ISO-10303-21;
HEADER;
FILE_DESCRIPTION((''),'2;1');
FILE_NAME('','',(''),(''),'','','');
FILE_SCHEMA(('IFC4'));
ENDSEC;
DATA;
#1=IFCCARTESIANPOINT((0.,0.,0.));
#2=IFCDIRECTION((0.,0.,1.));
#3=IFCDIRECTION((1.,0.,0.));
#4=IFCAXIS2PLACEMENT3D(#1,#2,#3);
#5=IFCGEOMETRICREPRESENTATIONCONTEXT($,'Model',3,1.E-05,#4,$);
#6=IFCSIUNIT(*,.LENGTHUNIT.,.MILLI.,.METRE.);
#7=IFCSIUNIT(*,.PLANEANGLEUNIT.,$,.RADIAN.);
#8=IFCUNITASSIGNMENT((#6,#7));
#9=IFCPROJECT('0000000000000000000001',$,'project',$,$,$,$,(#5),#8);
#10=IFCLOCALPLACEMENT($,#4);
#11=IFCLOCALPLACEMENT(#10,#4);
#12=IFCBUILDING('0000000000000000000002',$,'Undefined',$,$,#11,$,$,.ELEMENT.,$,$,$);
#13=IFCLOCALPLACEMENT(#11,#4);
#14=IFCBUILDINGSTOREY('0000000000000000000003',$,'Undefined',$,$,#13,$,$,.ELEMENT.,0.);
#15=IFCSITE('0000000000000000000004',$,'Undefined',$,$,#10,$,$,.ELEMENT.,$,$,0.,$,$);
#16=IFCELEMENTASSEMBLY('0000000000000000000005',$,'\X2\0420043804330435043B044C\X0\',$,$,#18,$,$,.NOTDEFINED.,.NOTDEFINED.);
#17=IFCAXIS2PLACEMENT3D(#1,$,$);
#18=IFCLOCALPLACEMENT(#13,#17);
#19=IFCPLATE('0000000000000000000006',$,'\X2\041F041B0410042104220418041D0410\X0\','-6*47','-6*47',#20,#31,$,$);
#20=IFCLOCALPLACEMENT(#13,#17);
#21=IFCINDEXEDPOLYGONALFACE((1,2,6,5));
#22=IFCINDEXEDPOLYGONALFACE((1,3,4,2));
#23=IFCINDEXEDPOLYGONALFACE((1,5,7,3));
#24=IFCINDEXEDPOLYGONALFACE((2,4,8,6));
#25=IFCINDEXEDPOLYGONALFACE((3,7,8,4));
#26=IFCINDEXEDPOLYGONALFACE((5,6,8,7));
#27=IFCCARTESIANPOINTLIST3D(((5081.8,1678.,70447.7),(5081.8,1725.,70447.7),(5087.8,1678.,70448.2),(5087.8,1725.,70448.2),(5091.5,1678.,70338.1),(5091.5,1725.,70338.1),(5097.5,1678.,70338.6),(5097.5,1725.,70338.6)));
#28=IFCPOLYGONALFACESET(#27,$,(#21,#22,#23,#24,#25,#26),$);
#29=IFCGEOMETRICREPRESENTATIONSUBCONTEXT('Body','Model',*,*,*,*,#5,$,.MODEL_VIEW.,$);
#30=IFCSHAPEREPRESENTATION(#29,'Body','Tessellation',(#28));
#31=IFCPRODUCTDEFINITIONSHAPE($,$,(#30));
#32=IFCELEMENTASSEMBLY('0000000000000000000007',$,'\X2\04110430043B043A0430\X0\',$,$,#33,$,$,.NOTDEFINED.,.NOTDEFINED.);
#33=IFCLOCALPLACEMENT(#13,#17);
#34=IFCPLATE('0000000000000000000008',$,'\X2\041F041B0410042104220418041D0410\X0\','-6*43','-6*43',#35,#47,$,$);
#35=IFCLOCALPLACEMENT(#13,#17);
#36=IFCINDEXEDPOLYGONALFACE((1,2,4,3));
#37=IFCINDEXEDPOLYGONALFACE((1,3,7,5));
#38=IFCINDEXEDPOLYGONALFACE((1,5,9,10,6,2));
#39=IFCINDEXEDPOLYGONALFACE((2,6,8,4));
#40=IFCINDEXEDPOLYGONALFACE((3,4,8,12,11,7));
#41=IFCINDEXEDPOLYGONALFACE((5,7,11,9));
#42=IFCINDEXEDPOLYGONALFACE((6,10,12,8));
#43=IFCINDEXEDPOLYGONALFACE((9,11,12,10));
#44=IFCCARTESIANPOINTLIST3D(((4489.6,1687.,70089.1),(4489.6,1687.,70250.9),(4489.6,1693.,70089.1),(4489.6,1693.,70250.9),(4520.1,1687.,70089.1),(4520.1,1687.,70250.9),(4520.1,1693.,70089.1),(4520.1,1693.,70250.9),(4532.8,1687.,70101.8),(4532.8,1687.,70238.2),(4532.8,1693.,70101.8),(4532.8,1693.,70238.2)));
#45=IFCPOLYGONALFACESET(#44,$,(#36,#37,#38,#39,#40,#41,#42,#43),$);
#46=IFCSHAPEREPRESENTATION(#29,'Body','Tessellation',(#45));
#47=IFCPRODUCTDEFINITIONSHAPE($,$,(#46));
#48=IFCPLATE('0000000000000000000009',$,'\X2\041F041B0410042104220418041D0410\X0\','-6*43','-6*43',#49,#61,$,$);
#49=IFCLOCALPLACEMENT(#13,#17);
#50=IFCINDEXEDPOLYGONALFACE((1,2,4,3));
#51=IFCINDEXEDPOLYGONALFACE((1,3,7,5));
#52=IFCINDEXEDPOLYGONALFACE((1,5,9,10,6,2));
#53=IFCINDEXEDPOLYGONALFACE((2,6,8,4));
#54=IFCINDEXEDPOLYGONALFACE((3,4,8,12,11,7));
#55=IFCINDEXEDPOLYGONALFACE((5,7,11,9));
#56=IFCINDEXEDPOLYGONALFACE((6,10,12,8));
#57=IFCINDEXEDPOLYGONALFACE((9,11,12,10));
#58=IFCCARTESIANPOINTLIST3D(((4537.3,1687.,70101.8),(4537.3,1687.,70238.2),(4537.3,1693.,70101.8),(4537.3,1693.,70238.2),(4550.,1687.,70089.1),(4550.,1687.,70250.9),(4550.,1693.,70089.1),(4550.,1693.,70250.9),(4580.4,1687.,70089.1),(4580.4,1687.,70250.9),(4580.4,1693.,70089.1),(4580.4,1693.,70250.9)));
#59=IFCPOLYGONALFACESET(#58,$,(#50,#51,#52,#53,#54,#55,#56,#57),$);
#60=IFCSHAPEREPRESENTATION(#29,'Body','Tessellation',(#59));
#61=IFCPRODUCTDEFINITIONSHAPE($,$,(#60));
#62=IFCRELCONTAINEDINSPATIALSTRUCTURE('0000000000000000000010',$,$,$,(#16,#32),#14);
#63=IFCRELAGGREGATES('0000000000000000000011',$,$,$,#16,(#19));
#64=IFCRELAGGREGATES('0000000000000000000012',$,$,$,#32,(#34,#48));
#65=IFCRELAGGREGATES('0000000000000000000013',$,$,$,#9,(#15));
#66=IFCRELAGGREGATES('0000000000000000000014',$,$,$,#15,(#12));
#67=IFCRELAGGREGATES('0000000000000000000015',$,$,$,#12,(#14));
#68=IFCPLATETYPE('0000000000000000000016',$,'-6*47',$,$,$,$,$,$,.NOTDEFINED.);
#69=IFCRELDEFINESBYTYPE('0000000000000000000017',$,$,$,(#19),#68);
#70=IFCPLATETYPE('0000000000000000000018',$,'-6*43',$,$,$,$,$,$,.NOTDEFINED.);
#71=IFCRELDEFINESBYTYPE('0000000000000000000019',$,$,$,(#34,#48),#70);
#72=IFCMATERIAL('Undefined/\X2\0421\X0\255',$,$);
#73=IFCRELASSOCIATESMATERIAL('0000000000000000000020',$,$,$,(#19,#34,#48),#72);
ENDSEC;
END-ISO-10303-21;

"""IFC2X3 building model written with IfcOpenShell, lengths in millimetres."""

from ifc_helpers import new_model, si_unit, frame, origin_with_axes, origin_2d_with_axis, place, context, subcontext, project, spatial, polyline, rectangle, outline, extrude, boolean, material, type_object, element, aggregate, save


model = new_model("IFC2X3")

# Units and contexts
model_context = context("Model", 3, precision=1e-05, world=origin_with_axes())
body_context = subcontext(model_context, "Body", "Model", "MODEL_VIEW")
ifc_project = project(units=[si_unit("LENGTHUNIT", "METRE", prefix="MILLI"), si_unit("PLANEANGLEUNIT", "RADIAN")], contexts=[model_context])

# Site, building, storey
site_placement = place(None, origin_with_axes())
site = spatial("IfcSite", under=ifc_project, at=site_placement, Name="Undefined", CompositionType="ELEMENT", RefElevation=0.0)
building_placement = place(site_placement, origin_with_axes())
building = spatial("IfcBuilding", under=site, at=building_placement, Name="Undefined", CompositionType="ELEMENT")
storey_placement = place(building_placement, origin_with_axes())
storey = spatial("IfcBuildingStorey", under=building, at=storey_placement, Name="Undefined", CompositionType="ELEMENT", Elevation=0.0)

# Shared definitions
ifc_material_1 = material(Name="Undefined/С255")

# Element assembly
assembly_1_placement = place(storey_placement, origin_with_axes())
assembly_1 = element("IfcElementAssembly", 1, at=assembly_1_placement, inside=storey, Name="Ригель", AssemblyPlace="NOTDEFINED", PredefinedType="NOTDEFINED")

# Plate
plate_type_1 = type_object("IfcPlateType", Name="-6*47", PredefinedType="NOTDEFINED")
plate_1_placement = place(assembly_1_placement, frame((5084.8, 1615.0, 70447.9), z_axis=(0.996107, 0.0, 0.088152), x_axis=(0.088152, 0.0, -0.996107)))
plate_1 = element("IfcPlate", 2, at=plate_1_placement, type_object=plate_type_1, material=ifc_material_1, Name="ПЛАСТИНА", Description="-6*47", ObjectType="-6*47", context=body_context, shape_type="CSG", body=[
    boolean("DIFFERENCE", extrude(outline(polyline([(0.0, 0.0), (110.0, 0.0), (110.0, 110.0), (0.0, 110.0), (0.0, 0.0)])), frame((0.0, 0.0, -3.0), z_axis=(0.0, 0.0, 1.0), x_axis=(1.0, 0.0, 0.0)), (0.0, 0.0, 1.0), 6.0), extrude(rectangle(XDim=26.0, YDim=130.0, at=origin_2d_with_axis()), frame((55.0, -3.0, 0.0), z_axis=(0.0, 1.0, 0.0), x_axis=(0.0, 0.0, -1.0)), (0.0, 0.0, 1.0), 66.0)),
])
aggregate(assembly_1, [plate_1])

# Element assembly, plates
assembly_2_placement = place(storey_placement, origin_with_axes())
assembly_2 = element("IfcElementAssembly", 3, at=assembly_2_placement, inside=storey, Name="Балка", AssemblyPlace="NOTDEFINED", PredefinedType="NOTDEFINED")
plate_type_2 = type_object("IfcPlateType", Name="-6*43", PredefinedType="NOTDEFINED")
plate_2_placement = place(assembly_2_placement, frame((4532.8, 1690.0, 70250.9), z_axis=(0.0, -1.0, 0.0), x_axis=(-1.0, 0.0, 0.0)))
plate_2 = element("IfcPlate", 4, at=plate_2_placement, type_object=plate_type_2, material=ifc_material_1, Name="ПЛАСТИНА", Description="-6*43", ObjectType="-6*43", context=body_context, shape_type="SweptSolid", body=[
    extrude(outline(polyline([(0.0, 12.7), (12.7, 0.0), (43.2, 0.0), (43.2, 161.8), (12.7, 161.8), (0.0, 149.1), (0.0, 12.7)])), frame((0.0, 0.0, -3.0), z_axis=(0.0, 0.0, 1.0), x_axis=(1.0, 0.0, 0.0)), (0.0, 0.0, 1.0), 6.0),
])
plate_3_placement = place(assembly_2_placement, frame((4580.4, 1690.0, 70250.9), z_axis=(0.0, -1.0, 0.0), x_axis=(-1.0, 0.0, 0.0)))
plate_3 = element("IfcPlate", 5, at=plate_3_placement, type_object=plate_type_2, material=ifc_material_1, Name="ПЛАСТИНА", Description="-6*43", ObjectType="-6*43", context=body_context, shape_type="SweptSolid", body=[
    extrude(outline(polyline([(0.0, 0.0), (30.5, 0.0), (43.2, 12.7), (43.2, 149.1), (30.5, 161.8), (0.0, 161.8), (0.0, 0.0)])), frame((0.0, 0.0, -3.0), z_axis=(0.0, 0.0, 1.0), x_axis=(1.0, 0.0, 0.0)), (0.0, 0.0, 1.0), 6.0),
])

aggregate(assembly_2, [plate_2, plate_3])

save(model, "model.ifc")
